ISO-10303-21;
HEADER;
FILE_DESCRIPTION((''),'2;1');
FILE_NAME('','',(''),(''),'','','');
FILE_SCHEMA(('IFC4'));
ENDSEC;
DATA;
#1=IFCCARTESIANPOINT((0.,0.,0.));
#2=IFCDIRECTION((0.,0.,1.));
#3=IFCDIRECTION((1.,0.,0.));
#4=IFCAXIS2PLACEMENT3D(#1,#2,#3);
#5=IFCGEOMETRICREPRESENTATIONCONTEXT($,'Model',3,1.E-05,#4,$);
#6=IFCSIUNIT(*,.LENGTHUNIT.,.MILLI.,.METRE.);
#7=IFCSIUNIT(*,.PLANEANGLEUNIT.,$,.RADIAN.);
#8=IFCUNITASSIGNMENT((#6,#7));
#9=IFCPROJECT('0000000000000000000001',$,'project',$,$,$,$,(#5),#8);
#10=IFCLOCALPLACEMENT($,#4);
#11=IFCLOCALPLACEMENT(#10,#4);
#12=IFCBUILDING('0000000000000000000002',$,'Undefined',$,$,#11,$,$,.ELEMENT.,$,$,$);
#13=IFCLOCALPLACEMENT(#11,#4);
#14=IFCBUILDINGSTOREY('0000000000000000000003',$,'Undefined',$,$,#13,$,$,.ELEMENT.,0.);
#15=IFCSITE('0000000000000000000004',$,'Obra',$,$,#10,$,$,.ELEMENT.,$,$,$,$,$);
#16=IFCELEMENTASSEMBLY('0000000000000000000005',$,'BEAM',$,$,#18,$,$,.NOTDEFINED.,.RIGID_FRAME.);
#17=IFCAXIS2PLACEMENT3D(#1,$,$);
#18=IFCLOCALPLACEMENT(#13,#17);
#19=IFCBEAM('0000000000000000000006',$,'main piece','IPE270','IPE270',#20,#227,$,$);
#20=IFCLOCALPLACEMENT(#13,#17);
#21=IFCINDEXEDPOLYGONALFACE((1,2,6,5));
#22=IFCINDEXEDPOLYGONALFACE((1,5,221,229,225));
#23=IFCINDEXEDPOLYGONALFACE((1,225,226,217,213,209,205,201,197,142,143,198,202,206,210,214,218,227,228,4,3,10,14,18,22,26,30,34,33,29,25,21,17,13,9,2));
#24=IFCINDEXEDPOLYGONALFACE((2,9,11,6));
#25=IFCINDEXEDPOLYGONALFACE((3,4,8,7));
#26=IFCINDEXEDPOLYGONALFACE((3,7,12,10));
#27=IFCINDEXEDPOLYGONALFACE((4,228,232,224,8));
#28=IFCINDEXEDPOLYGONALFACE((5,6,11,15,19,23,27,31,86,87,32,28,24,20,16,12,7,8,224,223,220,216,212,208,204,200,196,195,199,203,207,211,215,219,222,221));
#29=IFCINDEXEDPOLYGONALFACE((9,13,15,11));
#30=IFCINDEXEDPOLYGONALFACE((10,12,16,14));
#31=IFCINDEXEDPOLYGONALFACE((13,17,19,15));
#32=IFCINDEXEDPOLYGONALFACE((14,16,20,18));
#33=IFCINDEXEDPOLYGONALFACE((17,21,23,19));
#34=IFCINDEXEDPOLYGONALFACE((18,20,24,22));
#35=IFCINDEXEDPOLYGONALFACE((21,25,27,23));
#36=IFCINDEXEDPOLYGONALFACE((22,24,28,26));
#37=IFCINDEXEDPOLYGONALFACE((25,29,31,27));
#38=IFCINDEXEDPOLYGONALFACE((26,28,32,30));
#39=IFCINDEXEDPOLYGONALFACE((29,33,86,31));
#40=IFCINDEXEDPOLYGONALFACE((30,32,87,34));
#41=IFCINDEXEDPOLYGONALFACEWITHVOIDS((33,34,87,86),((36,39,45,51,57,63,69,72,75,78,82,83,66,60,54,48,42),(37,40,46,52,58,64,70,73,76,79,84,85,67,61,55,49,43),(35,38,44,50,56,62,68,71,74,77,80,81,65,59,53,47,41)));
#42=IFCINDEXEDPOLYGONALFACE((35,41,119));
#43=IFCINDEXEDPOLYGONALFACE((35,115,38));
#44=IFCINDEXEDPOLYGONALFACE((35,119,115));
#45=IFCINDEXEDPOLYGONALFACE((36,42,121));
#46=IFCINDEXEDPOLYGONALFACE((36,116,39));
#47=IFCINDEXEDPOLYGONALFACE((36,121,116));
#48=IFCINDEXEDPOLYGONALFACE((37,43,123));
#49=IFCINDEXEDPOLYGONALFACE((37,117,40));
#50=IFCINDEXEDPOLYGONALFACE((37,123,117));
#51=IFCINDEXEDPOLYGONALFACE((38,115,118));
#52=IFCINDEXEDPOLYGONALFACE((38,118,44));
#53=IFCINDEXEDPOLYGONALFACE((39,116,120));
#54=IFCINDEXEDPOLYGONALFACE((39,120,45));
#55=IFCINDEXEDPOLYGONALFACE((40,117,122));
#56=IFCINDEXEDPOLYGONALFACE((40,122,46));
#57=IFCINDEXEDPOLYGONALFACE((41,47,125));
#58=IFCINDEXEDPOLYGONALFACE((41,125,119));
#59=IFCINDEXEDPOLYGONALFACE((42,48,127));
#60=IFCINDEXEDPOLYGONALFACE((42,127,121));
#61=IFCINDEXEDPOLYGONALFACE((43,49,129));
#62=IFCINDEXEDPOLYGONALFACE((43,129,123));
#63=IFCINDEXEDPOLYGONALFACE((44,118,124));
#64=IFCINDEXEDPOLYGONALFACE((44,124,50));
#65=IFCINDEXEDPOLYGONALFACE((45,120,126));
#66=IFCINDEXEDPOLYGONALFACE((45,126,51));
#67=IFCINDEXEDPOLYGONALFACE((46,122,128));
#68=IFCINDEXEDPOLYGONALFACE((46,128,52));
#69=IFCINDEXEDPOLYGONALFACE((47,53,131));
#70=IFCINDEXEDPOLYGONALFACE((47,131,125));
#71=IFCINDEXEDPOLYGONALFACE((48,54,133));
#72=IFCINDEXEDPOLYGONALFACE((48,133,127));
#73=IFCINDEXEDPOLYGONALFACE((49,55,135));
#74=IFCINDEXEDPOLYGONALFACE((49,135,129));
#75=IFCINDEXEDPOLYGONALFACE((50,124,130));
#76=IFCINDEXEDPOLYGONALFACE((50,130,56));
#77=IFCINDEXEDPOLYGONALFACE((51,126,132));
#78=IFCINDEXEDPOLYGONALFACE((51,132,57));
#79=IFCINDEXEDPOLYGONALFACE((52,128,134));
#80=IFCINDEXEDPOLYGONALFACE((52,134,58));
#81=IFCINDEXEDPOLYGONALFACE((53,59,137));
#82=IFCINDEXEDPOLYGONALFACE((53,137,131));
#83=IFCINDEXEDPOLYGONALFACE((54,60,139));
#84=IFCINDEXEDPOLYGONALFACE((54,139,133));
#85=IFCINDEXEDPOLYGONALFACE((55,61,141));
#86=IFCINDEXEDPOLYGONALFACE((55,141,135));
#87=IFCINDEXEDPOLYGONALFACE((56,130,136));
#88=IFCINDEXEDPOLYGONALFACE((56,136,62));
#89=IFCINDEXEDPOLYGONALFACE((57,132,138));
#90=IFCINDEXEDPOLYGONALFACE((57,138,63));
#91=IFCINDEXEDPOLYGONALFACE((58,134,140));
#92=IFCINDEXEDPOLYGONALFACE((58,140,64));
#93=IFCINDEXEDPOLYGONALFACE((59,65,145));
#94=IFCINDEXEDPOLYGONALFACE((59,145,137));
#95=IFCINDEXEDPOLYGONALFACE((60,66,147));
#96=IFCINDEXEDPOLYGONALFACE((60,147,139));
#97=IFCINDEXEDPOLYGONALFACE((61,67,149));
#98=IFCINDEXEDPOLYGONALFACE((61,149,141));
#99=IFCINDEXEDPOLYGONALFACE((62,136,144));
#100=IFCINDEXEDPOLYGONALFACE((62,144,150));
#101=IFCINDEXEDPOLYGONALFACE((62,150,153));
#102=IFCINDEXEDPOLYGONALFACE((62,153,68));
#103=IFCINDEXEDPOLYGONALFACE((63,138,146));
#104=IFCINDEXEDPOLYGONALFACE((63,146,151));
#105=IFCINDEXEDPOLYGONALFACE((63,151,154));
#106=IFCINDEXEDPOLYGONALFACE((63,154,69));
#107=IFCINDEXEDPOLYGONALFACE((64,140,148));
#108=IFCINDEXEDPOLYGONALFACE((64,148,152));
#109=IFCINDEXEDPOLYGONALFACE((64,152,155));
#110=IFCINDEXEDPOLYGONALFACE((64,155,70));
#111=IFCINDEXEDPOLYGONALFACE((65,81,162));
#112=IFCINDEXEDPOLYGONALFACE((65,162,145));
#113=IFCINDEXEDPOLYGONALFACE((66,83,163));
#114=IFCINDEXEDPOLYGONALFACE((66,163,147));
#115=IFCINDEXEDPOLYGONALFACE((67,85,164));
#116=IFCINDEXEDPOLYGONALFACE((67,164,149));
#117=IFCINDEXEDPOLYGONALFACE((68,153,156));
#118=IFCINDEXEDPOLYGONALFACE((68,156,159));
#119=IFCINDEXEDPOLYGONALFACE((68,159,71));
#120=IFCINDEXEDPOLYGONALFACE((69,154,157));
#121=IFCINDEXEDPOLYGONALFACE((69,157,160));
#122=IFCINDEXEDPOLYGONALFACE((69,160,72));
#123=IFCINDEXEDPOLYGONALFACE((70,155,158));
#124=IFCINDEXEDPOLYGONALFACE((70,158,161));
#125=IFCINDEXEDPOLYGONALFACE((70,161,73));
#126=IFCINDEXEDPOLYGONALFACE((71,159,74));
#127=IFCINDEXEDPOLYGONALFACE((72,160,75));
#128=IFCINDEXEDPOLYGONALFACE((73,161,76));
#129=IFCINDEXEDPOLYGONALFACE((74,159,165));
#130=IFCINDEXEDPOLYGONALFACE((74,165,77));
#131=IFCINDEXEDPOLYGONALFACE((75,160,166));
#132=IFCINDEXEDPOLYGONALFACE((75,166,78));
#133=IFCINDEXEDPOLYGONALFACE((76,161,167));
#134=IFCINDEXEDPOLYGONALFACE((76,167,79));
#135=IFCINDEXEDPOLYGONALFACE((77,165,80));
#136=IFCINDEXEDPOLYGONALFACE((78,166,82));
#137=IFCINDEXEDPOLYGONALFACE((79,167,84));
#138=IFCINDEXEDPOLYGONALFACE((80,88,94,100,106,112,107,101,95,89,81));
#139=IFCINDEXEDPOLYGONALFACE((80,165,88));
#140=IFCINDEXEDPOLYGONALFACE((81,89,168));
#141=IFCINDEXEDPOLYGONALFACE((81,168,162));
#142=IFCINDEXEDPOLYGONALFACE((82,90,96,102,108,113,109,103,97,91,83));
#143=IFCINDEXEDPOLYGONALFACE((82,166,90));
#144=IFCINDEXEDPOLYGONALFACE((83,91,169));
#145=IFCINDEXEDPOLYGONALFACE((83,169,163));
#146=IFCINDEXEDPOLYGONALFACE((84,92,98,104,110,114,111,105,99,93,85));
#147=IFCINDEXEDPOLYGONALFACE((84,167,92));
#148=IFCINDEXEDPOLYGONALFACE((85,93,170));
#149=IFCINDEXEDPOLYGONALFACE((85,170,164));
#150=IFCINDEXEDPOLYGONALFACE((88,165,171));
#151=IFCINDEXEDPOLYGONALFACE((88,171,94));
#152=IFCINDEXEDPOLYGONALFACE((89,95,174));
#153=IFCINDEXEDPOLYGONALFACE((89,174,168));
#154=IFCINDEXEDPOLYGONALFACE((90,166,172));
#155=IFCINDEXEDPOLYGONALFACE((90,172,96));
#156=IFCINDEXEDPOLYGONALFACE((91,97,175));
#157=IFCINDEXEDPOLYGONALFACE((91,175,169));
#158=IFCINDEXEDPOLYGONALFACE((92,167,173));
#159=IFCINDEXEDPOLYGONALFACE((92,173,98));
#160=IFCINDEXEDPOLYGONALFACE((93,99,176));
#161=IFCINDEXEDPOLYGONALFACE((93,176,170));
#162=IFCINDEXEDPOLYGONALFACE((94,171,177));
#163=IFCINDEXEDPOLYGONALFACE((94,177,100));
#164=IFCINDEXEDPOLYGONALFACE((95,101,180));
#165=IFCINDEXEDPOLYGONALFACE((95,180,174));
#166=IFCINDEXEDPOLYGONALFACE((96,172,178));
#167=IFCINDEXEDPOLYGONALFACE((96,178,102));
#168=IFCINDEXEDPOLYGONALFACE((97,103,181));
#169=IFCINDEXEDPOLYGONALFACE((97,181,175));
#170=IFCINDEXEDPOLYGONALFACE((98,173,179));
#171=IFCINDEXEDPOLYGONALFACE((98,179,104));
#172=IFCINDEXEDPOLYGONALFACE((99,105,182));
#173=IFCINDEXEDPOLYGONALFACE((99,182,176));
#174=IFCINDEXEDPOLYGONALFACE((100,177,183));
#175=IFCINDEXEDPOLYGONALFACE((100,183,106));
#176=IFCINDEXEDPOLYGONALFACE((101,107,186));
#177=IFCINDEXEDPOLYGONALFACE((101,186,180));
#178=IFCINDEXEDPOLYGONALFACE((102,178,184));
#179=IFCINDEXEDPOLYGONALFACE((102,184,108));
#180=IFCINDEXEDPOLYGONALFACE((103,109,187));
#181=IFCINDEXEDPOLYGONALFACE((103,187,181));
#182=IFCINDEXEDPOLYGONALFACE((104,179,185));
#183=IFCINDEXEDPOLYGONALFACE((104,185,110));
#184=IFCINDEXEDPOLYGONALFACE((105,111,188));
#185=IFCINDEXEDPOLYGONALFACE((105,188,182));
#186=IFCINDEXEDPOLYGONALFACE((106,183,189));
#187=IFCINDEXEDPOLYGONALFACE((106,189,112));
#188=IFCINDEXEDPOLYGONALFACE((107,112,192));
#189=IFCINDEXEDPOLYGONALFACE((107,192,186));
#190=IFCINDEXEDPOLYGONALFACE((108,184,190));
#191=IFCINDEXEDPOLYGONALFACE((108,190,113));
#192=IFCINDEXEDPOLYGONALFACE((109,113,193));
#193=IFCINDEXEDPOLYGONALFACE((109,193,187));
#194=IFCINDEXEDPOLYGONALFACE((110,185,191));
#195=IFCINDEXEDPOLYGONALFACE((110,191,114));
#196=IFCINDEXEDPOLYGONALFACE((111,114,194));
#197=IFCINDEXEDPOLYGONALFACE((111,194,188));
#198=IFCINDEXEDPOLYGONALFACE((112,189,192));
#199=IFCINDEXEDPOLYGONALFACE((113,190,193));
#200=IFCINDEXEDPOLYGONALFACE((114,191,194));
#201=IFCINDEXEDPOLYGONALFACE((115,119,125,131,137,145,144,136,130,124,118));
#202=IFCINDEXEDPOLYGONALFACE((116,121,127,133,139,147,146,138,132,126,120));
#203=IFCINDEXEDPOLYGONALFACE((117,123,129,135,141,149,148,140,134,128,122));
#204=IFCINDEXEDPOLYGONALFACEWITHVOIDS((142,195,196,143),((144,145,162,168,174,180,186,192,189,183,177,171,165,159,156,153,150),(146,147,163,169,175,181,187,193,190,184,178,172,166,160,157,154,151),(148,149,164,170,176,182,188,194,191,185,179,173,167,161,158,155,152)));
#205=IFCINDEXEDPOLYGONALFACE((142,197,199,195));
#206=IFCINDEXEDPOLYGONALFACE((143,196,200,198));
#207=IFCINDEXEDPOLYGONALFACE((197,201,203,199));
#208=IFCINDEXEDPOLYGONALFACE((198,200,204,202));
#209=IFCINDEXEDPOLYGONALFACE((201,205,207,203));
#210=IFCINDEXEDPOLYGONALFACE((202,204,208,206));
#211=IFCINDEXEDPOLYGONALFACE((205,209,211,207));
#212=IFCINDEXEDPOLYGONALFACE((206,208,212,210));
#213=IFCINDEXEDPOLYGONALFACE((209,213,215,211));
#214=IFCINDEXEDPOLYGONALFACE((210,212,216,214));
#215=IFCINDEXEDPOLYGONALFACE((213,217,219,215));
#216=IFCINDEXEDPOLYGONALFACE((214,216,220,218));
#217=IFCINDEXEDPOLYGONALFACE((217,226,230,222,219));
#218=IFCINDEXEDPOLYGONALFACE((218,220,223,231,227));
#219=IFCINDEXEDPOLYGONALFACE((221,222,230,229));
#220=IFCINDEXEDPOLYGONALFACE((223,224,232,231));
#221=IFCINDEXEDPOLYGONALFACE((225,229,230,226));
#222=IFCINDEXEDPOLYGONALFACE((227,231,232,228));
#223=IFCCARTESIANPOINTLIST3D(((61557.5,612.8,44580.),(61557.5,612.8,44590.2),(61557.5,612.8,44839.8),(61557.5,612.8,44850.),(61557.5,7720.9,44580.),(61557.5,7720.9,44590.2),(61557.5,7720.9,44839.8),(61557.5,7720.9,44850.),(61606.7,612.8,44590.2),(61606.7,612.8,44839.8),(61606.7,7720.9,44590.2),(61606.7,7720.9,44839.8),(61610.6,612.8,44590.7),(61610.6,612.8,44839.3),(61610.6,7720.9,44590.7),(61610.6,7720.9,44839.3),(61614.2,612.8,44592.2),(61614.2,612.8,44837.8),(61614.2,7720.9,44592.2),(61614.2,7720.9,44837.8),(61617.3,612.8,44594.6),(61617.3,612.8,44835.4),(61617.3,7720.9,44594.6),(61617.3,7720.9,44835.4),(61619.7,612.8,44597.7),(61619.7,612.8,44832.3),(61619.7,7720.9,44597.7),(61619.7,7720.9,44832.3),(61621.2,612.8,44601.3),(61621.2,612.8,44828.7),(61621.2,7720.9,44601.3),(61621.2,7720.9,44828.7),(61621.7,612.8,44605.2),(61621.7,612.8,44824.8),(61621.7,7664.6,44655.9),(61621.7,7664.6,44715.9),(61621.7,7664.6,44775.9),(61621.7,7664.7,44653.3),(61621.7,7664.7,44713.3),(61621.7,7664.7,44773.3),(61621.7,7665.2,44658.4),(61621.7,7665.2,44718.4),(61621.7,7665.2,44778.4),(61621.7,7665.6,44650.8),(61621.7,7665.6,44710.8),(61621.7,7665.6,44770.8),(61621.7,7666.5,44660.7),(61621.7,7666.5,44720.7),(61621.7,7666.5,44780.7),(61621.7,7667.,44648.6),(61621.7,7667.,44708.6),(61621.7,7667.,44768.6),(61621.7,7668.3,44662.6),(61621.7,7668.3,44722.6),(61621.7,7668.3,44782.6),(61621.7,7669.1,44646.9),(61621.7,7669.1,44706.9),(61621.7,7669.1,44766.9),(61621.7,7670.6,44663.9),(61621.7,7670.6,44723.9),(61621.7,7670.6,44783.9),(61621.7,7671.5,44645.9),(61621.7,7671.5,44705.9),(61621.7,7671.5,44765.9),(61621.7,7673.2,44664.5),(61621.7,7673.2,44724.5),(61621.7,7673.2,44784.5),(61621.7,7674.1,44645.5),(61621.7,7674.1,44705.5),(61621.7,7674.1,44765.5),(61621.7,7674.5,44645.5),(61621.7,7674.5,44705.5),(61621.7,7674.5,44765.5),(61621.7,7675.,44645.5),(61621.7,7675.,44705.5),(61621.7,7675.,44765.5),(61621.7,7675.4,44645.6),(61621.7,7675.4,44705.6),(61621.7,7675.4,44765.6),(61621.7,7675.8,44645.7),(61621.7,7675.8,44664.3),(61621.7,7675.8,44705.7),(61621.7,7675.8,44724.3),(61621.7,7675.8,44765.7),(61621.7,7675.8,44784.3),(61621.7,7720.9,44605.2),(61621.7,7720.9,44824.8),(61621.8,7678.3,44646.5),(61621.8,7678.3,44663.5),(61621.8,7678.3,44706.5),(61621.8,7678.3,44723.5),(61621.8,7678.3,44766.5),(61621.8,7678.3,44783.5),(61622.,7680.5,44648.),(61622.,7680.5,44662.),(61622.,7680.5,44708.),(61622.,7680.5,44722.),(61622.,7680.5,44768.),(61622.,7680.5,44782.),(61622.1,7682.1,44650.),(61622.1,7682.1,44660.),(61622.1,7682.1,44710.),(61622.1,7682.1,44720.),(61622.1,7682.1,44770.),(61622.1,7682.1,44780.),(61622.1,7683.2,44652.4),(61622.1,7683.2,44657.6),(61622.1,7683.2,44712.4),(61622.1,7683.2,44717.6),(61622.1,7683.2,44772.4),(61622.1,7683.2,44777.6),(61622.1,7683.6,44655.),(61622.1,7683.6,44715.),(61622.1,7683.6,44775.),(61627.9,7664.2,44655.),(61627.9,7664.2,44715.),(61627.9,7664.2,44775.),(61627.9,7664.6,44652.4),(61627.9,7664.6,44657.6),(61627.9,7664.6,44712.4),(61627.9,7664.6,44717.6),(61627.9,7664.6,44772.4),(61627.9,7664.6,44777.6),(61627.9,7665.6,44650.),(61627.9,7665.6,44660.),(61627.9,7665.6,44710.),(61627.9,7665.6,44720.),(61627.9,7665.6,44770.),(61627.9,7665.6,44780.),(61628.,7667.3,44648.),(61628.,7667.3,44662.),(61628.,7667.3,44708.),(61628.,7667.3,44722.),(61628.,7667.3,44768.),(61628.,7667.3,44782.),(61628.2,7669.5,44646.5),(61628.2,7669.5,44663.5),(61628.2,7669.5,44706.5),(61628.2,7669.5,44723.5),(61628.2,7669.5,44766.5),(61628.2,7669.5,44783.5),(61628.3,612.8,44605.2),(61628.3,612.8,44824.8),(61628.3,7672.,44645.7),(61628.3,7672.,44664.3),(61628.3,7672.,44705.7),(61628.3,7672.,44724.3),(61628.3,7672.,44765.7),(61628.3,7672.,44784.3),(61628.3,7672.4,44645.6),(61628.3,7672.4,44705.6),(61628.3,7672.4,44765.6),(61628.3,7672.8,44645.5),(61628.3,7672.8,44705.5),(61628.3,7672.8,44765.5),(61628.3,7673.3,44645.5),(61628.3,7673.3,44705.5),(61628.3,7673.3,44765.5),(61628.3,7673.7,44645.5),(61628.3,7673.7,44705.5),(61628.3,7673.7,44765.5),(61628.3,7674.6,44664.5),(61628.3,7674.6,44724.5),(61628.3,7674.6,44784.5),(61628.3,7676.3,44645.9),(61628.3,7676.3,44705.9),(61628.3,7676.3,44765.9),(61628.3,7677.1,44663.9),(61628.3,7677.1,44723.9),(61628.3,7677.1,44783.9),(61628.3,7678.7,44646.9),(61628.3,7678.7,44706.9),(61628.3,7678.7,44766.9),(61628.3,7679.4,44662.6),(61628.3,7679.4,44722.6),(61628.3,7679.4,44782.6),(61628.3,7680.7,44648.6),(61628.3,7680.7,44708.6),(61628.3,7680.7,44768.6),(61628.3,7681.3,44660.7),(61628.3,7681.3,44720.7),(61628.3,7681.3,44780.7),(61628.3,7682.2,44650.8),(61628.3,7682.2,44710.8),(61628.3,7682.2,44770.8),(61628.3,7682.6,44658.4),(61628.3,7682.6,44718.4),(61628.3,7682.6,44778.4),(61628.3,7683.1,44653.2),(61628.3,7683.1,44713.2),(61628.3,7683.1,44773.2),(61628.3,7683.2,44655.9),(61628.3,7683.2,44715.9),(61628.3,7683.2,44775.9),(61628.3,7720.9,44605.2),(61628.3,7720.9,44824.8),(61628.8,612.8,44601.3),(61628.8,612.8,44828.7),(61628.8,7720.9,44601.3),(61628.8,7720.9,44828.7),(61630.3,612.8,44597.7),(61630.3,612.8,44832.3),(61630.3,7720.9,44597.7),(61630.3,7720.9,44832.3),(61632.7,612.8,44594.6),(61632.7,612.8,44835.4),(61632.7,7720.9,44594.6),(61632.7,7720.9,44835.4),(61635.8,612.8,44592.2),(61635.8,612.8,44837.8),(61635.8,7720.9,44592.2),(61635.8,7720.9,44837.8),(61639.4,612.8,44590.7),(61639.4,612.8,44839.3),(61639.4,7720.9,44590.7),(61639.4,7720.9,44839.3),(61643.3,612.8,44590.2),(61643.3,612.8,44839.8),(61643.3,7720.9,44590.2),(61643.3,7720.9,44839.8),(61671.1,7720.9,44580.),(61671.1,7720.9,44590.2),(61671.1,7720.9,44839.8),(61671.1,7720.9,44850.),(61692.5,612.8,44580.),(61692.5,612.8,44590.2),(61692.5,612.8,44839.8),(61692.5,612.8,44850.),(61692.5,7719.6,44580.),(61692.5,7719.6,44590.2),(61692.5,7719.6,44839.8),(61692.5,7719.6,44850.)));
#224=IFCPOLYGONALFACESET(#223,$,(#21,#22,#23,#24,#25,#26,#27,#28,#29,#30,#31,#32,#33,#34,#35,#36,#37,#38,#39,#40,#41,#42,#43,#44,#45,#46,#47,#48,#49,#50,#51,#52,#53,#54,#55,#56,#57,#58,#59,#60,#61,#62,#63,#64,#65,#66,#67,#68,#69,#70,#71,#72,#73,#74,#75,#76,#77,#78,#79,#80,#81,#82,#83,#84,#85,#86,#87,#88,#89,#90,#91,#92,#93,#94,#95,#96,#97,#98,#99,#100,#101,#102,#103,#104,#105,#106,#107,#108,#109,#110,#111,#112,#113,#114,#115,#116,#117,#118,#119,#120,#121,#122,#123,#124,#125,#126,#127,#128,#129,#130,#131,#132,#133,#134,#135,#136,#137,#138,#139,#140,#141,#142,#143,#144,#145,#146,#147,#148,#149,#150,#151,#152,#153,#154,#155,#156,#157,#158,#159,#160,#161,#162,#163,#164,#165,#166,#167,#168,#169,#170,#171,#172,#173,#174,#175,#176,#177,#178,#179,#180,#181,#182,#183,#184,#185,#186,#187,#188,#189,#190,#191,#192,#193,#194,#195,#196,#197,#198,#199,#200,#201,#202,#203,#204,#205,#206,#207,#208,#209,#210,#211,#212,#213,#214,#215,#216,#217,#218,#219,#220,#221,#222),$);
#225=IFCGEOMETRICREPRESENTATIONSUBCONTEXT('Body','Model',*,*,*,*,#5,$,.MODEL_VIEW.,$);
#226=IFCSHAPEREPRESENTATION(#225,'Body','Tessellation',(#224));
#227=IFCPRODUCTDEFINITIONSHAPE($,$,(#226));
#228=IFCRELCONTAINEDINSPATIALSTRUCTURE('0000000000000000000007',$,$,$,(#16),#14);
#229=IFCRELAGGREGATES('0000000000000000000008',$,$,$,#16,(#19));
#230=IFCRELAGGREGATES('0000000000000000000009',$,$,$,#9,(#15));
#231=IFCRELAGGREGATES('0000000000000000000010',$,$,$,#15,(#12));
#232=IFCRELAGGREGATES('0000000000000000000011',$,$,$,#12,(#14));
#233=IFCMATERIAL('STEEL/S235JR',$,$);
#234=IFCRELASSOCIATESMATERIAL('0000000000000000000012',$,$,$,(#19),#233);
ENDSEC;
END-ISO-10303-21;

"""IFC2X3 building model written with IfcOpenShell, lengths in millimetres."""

from ifc_helpers import new_model, si_unit, frame, origin_with_axes, origin_2d_with_axis, place, context, subcontext, project, spatial, circle, i_section, extrude, clip, halfspace, source, transform, mapped, material, element, aggregate, save


model = new_model("IFC2X3")

# Units and contexts
model_context = context("Model", 3, precision=1e-05, world=origin_with_axes())
body_context = subcontext(model_context, "Body", "Model", "MODEL_VIEW")
ifc_project = project(units=[si_unit("LENGTHUNIT", "METRE", prefix="MILLI"), si_unit("PLANEANGLEUNIT", "RADIAN")], contexts=[model_context])

# Site, building, storey
site_placement = place(None, origin_with_axes())
site = spatial("IfcSite", under=ifc_project, at=site_placement, Name="Obra", CompositionType="ELEMENT")
building_placement = place(site_placement, origin_with_axes())
building = spatial("IfcBuilding", under=site, at=building_placement, Name="Undefined", CompositionType="ELEMENT")
storey_placement = place(building_placement, origin_with_axes())
storey = spatial("IfcBuildingStorey", under=building, at=storey_placement, Name="Undefined", CompositionType="ELEMENT", Elevation=0.0)

# Shared definitions
ifc_material_1 = material(Name="STEEL/S235JR")

# Element assembly, beam, opening
shared_shape_1 = source(origin_with_axes(), body_context, "Body", "SweptSolid", [
    extrude(circle(Radius=9.5, at=origin_2d_with_axis()), frame((0.0, 28.6, 0.0), z_axis=(0.0, 1.0, 0.0), x_axis=(1.0, 0.0, 0.0)), (0.0, 0.0, 1.0), 6.8),
])
assembly_1_placement = place(storey_placement, origin_with_axes())
assembly_1 = element("IfcElementAssembly", 1, at=assembly_1_placement, inside=storey, Name="BEAM", AssemblyPlace="NOTDEFINED", PredefinedType="RIGID_FRAME")
beam_1_placement = place(assembly_1_placement, frame((61625.0, 7720.9, 44715.0), z_axis=(0.0, 0.0, 1.0), x_axis=(0.0, -1.0, 0.0)))
beam_1 = element("IfcBeam", 2, at=beam_1_placement, material=ifc_material_1, Name="main piece", Description="IPE270", ObjectType="IPE270", context=body_context, shape_type="Clipping", body=[
    clip(extrude(i_section(OverallWidth=135.0, OverallDepth=270.0, WebThickness=6.6, FlangeThickness=10.2, FilletRadius=15.0, at=origin_2d_with_axis()), frame((7108.1, 0.0, 0.0), z_axis=(-1.0, 0.0, 0.0), x_axis=(0.0, -1.0, 0.0)), (0.0, 0.0, 1.0), 7108.1), halfspace(frame((-0.9, 30.8, -120.0), z_axis=(-0.998369, 0.057091, 0.0), x_axis=(0.0, 0.0, 1.0)), False)),
])
opening_1_placement = place(assembly_1_placement, frame((61595.9, 7725.6, 44835.0), z_axis=(-0.05711, -0.998368, 0.0), x_axis=(0.0, 0.0, -1.0)))
element("IfcOpeningElement", 3, at=opening_1_placement, cuts=beam_1, ObjectType="Opening", context=body_context, shape_type="MappedRepresentation", body=[
    mapped(shared_shape_1, transform((60.0, 0.0, 50.0))),
    mapped(shared_shape_1, transform((120.0, 0.0, 50.0))),
    mapped(shared_shape_1, transform((180.0, 0.0, 50.0))),
])

aggregate(assembly_1, [beam_1])

save(model, "model.ifc")
